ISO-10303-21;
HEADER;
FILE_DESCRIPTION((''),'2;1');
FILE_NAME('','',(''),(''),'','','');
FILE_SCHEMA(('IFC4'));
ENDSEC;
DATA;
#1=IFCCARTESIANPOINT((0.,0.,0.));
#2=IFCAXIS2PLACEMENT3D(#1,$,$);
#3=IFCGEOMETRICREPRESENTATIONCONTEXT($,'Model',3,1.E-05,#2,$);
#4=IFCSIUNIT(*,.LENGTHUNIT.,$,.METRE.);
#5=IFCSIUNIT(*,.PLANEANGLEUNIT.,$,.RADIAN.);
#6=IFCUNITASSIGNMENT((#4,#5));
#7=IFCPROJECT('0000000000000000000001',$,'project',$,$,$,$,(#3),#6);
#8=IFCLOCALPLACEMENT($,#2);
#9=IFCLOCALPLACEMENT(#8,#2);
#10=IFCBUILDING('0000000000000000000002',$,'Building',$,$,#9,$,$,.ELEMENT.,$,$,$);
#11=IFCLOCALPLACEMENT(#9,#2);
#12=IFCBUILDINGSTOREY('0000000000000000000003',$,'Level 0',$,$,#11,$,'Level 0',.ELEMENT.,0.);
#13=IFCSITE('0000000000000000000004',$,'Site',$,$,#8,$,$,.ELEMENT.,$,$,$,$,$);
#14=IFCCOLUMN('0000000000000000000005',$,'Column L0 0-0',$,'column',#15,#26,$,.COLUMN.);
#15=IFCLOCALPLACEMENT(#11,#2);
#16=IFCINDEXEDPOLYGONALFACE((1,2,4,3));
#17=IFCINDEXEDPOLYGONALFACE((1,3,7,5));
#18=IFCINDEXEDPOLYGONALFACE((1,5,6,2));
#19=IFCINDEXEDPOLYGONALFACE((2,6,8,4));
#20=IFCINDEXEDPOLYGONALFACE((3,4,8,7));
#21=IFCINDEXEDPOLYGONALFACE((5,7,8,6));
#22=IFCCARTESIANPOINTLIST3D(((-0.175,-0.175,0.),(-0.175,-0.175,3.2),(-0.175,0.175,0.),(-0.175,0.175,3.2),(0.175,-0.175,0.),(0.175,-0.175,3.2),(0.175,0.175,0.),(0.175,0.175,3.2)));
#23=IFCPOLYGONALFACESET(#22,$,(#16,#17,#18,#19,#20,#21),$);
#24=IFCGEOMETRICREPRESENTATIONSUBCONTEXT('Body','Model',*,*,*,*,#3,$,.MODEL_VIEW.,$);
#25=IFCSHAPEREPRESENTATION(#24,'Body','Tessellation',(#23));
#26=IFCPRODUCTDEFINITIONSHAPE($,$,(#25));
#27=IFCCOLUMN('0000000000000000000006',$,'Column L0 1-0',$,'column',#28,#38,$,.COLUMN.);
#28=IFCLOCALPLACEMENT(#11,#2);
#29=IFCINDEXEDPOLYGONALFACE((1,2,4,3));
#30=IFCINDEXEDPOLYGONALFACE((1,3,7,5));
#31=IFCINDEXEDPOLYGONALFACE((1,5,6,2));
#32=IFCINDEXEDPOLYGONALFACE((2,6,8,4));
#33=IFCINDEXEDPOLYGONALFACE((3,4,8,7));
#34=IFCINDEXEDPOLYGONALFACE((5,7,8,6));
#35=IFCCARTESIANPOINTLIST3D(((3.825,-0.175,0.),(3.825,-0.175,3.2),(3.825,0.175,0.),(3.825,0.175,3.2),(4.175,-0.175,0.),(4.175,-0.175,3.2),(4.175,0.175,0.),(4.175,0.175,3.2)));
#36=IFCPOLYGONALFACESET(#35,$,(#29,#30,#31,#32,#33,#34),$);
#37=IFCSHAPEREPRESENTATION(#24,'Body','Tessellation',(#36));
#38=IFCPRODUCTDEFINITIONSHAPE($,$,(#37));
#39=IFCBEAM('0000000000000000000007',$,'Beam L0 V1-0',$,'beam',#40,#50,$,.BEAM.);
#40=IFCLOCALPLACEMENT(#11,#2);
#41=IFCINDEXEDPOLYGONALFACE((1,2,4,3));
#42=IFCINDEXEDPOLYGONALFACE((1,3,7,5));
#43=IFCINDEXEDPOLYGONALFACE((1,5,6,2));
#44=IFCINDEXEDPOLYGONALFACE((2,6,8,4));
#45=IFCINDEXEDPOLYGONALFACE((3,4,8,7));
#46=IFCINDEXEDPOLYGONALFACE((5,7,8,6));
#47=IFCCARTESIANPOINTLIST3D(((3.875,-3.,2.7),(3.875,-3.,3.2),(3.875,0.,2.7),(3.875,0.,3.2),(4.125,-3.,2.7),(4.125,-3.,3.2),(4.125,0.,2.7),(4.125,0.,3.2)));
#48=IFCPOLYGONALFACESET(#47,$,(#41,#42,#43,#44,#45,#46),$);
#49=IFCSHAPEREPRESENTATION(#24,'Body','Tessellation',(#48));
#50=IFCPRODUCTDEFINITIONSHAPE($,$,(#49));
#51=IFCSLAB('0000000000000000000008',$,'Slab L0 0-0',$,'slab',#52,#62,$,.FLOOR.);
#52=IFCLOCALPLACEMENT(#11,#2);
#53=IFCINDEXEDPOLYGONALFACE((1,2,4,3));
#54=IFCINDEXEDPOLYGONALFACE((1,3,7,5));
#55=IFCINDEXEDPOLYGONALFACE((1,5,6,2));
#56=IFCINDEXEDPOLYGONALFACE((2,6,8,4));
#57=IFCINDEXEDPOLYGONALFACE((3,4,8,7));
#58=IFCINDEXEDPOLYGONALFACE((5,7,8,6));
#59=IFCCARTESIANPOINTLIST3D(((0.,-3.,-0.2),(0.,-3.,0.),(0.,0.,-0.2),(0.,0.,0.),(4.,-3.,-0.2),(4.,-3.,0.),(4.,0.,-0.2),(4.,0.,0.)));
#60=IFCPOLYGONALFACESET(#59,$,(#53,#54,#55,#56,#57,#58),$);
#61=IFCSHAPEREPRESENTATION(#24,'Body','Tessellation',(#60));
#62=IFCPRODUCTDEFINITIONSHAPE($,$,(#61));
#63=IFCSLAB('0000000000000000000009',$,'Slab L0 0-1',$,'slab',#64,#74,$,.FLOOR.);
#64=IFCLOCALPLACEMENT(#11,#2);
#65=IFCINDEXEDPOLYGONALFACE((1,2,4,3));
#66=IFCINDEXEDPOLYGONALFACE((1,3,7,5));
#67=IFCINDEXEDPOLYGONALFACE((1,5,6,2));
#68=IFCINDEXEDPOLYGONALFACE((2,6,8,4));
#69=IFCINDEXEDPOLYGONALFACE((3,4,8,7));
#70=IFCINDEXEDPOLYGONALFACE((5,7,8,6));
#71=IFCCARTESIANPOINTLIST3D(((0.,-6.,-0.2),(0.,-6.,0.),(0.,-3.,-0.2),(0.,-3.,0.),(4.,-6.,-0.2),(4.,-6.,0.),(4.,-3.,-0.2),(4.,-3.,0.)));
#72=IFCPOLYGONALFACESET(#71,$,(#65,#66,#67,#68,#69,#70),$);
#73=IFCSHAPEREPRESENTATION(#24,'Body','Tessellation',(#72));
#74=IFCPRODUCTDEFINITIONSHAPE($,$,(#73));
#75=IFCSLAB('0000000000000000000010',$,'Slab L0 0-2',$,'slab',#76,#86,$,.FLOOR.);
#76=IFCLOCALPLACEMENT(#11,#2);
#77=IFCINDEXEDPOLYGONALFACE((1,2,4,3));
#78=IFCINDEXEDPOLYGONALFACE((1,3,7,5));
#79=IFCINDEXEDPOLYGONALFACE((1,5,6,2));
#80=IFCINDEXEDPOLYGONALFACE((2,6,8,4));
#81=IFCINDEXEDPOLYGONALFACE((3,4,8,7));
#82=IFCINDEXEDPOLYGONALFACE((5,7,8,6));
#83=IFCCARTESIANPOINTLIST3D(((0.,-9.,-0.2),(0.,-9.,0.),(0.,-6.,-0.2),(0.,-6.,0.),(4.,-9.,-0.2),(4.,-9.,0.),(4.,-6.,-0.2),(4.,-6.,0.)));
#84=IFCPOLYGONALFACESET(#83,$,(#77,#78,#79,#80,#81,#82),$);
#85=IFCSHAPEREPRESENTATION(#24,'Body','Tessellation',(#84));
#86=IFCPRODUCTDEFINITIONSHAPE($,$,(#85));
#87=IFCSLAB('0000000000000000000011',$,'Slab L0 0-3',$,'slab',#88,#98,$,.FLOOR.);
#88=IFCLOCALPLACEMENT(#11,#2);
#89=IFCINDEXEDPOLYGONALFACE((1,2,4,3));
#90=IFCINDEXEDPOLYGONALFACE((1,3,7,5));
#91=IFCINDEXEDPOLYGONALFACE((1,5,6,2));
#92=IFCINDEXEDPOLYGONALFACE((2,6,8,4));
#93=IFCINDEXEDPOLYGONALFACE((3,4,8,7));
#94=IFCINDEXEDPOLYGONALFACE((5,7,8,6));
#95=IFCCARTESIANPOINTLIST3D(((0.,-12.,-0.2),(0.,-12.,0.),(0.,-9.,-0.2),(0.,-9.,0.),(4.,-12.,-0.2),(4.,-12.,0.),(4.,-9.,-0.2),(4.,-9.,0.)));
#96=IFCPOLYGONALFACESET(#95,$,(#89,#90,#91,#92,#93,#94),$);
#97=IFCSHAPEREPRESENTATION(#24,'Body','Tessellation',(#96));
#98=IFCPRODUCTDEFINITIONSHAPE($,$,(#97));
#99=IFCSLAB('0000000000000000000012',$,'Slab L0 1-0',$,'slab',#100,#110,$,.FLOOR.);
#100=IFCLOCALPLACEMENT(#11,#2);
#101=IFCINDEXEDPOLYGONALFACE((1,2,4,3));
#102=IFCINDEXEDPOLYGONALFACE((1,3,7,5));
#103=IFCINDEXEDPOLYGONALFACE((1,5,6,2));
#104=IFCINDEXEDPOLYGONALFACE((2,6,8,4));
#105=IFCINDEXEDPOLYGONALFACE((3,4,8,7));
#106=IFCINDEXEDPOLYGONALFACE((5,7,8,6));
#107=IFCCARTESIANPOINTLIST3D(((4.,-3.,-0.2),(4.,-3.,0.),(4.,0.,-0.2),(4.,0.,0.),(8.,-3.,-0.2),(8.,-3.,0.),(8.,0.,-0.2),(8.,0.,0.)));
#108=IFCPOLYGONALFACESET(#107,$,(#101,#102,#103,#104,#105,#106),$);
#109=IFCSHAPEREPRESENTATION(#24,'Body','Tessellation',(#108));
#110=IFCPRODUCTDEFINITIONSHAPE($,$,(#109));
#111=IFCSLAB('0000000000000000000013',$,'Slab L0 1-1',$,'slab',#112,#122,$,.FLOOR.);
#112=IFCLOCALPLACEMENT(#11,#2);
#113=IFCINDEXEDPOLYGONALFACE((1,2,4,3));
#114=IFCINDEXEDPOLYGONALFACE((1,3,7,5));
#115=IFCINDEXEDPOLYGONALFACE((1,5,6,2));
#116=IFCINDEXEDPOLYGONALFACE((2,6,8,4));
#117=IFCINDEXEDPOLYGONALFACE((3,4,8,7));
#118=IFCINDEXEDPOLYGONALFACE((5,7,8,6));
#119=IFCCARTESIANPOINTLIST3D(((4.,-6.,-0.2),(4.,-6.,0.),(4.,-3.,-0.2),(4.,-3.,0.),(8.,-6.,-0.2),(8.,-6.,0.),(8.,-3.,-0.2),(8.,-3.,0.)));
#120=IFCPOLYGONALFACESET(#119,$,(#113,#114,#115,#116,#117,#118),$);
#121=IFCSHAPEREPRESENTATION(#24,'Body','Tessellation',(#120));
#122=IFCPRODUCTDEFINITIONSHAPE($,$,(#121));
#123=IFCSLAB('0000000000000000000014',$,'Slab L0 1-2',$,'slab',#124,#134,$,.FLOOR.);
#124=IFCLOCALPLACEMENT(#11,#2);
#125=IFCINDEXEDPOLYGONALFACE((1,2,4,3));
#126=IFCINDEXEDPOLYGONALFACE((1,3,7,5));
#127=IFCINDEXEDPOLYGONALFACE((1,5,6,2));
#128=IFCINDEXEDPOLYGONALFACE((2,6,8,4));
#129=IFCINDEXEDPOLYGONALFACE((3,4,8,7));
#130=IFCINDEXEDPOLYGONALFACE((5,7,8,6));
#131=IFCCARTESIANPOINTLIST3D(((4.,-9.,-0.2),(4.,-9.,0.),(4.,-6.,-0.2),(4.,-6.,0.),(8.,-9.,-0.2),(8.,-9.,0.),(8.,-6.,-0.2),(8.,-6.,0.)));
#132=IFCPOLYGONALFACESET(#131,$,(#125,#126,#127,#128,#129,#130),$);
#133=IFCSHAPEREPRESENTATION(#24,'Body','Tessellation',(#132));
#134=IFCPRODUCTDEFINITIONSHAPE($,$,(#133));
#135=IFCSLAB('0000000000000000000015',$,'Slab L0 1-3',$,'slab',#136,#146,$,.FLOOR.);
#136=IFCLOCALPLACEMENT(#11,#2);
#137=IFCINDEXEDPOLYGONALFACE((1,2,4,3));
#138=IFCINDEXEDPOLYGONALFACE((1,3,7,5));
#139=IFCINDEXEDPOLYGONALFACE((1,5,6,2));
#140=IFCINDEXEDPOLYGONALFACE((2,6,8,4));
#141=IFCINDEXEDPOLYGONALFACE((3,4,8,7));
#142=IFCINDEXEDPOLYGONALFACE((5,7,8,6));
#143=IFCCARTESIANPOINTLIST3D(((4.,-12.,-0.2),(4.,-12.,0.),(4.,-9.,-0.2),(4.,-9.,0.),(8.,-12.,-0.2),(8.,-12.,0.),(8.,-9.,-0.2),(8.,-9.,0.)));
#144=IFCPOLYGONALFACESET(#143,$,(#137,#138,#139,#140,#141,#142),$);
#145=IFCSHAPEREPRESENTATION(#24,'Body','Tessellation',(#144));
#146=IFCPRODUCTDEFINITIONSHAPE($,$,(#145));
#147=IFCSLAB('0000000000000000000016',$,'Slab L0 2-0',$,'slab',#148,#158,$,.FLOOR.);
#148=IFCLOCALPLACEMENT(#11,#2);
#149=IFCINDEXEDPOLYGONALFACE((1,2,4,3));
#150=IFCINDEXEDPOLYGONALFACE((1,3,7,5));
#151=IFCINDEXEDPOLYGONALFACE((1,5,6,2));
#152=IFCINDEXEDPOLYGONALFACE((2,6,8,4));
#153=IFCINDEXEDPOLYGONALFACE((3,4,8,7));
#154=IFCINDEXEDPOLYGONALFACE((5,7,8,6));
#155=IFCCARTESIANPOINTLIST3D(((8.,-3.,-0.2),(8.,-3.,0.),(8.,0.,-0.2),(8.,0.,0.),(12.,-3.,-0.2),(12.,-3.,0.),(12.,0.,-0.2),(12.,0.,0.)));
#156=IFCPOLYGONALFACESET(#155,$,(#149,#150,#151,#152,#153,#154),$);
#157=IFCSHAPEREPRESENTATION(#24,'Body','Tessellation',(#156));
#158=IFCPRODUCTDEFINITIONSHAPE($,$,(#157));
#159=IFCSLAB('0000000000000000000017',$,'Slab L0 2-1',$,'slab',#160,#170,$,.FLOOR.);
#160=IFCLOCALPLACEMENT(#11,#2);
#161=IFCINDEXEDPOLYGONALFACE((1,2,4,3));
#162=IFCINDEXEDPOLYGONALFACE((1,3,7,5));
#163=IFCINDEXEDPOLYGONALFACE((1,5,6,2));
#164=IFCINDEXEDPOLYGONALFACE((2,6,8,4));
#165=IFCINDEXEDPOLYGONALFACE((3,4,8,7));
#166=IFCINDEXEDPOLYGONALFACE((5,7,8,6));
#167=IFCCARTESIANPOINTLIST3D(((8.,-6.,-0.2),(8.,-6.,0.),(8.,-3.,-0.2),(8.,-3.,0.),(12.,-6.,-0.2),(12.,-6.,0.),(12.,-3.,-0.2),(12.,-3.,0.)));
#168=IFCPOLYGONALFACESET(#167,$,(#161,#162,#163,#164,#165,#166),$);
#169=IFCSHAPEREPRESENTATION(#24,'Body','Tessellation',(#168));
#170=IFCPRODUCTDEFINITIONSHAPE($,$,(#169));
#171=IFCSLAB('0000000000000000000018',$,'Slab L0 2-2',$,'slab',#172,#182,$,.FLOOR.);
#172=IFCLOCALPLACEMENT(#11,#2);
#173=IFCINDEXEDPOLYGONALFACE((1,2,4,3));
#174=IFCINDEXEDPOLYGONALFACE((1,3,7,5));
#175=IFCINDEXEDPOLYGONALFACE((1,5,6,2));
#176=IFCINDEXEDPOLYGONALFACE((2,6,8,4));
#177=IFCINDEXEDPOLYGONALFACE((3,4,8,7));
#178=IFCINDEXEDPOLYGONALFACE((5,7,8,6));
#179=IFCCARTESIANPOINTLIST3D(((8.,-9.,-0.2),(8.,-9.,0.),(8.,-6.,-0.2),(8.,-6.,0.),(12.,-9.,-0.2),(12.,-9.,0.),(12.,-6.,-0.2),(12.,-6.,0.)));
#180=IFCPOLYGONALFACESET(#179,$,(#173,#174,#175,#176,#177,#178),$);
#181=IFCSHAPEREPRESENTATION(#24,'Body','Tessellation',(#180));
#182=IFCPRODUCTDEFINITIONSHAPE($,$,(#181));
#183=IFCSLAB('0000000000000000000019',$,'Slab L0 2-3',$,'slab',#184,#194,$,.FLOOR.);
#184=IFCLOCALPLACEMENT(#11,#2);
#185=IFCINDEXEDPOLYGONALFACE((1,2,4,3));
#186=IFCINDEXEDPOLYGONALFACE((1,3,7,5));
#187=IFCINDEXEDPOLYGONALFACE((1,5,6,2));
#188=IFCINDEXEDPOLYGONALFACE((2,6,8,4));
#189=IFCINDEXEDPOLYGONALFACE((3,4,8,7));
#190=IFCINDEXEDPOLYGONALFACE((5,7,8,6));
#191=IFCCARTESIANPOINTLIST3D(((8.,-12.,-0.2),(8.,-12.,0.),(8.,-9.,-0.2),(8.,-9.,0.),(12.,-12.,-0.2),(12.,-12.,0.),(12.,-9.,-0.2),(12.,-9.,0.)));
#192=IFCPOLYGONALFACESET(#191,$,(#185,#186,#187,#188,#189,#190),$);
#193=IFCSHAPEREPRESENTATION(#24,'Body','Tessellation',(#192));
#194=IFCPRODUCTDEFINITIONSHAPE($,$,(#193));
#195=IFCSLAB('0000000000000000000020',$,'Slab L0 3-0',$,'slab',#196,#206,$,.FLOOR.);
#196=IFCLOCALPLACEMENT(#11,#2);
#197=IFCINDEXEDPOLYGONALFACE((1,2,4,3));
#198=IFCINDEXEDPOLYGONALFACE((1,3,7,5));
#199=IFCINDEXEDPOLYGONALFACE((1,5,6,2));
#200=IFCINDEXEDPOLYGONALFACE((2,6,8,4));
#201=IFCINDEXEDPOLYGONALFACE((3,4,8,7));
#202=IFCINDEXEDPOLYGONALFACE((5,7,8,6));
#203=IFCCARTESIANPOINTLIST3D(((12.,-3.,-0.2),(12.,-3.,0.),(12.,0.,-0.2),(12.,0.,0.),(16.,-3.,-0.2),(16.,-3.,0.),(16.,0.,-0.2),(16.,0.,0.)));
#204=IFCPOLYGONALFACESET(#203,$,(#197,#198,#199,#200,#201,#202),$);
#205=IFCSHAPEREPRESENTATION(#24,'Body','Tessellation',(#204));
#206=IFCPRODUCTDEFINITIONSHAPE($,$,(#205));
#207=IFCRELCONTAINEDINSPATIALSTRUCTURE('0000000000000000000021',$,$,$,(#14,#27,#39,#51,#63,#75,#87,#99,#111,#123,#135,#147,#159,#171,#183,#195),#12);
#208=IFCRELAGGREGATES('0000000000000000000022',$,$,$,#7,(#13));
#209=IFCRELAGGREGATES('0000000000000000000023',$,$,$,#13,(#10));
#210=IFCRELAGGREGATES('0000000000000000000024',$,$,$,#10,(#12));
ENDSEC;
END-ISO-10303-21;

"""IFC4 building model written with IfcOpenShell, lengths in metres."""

from ifc_helpers import new_model, si_unit, frame, origin, origin_2d, place, context, subcontext, project, spatial, polyline, rectangle, outline, extrude, element, save


model = new_model("IFC4")

# Units and contexts
model_context = context("Model", 3, precision=1e-05, world=origin())
body_context = subcontext(model_context, "Body", "Model", "MODEL_VIEW")
ifc_project = project(units=[si_unit("LENGTHUNIT", "METRE"), si_unit("PLANEANGLEUNIT", "RADIAN")], contexts=[model_context])

# Site, building, storey
site_placement = place(None, origin())
site = spatial("IfcSite", under=ifc_project, at=site_placement, Name="Site", CompositionType="ELEMENT")
building_placement = place(site_placement, origin())
building = spatial("IfcBuilding", under=site, at=building_placement, Name="Building", CompositionType="ELEMENT")
storey_placement = place(building_placement, origin())
storey = spatial("IfcBuildingStorey", under=building, at=storey_placement, Name="Level 0", LongName="Level 0", CompositionType="ELEMENT", Elevation=0.0)

# Columns
for number, where, name in (
    (1, (0.0, 0.0, 0.0), "Column L0 0-0"),
    (2, (4.0, 0.0, 0.0), "Column L0 1-0"),
):
    element("IfcColumn", number, at=place(storey_placement, frame(where)), inside=storey, Name=name, ObjectType="column", PredefinedType="COLUMN", context=body_context, shape_type="SweptSolid", body=[
        extrude(rectangle(XDim=0.35, YDim=0.35, at=origin_2d()), origin(), (0.0, 0.0, 1.0), 3.2),
    ])

# Beam
beam_placement = place(storey_placement, frame((4.0, 0.0, 2.95), z_axis=(0.0, -1.0, 0.0), x_axis=(0.0, 0.0, 1.0)))
element("IfcBeam", 3, at=beam_placement, inside=storey, Name="Beam L0 V1-0", ObjectType="beam", PredefinedType="BEAM", context=body_context, shape_type="SweptSolid", body=[
    extrude(rectangle(XDim=0.5, YDim=0.25, at=origin_2d()), origin(), (0.0, 0.0, 1.0), 3.0),
])

# Slabs
slab_1_placement = place(storey_placement, frame((0.0, 0.0, -0.2)))
element("IfcSlab", 4, at=slab_1_placement, inside=storey, Name="Slab L0 0-0", ObjectType="slab", PredefinedType="FLOOR", context=body_context, shape_type="SweptSolid", body=[
    extrude(outline(polyline([(0.0, -3.0), (4.0, -3.0), (4.0, 0.0), (0.0, 0.0), (0.0, -3.0)])), origin(), (0.0, 0.0, 1.0), 0.2),
])
slab_2_placement = place(storey_placement, frame((0.0, 0.0, -0.2)))
element("IfcSlab", 5, at=slab_2_placement, inside=storey, Name="Slab L0 0-1", ObjectType="slab", PredefinedType="FLOOR", context=body_context, shape_type="SweptSolid", body=[
    extrude(outline(polyline([(0.0, -6.0), (4.0, -6.0), (4.0, -3.0), (0.0, -3.0), (0.0, -6.0)])), origin(), (0.0, 0.0, 1.0), 0.2),
])
slab_3_placement = place(storey_placement, frame((0.0, 0.0, -0.2)))
element("IfcSlab", 6, at=slab_3_placement, inside=storey, Name="Slab L0 0-2", ObjectType="slab", PredefinedType="FLOOR", context=body_context, shape_type="SweptSolid", body=[
    extrude(outline(polyline([(0.0, -9.0), (4.0, -9.0), (4.0, -6.0), (0.0, -6.0), (0.0, -9.0)])), origin(), (0.0, 0.0, 1.0), 0.2),
])
slab_4_placement = place(storey_placement, frame((0.0, 0.0, -0.2)))
element("IfcSlab", 7, at=slab_4_placement, inside=storey, Name="Slab L0 0-3", ObjectType="slab", PredefinedType="FLOOR", context=body_context, shape_type="SweptSolid", body=[
    extrude(outline(polyline([(0.0, -12.0), (4.0, -12.0), (4.0, -9.0), (0.0, -9.0), (0.0, -12.0)])), origin(), (0.0, 0.0, 1.0), 0.2),
])
slab_5_placement = place(storey_placement, frame((0.0, 0.0, -0.2)))
element("IfcSlab", 8, at=slab_5_placement, inside=storey, Name="Slab L0 1-0", ObjectType="slab", PredefinedType="FLOOR", context=body_context, shape_type="SweptSolid", body=[
    extrude(outline(polyline([(4.0, -3.0), (8.0, -3.0), (8.0, 0.0), (4.0, 0.0), (4.0, -3.0)])), origin(), (0.0, 0.0, 1.0), 0.2),
])
slab_6_placement = place(storey_placement, frame((0.0, 0.0, -0.2)))
element("IfcSlab", 9, at=slab_6_placement, inside=storey, Name="Slab L0 1-1", ObjectType="slab", PredefinedType="FLOOR", context=body_context, shape_type="SweptSolid", body=[
    extrude(outline(polyline([(4.0, -6.0), (8.0, -6.0), (8.0, -3.0), (4.0, -3.0), (4.0, -6.0)])), origin(), (0.0, 0.0, 1.0), 0.2),
])
slab_7_placement = place(storey_placement, frame((0.0, 0.0, -0.2)))
element("IfcSlab", 10, at=slab_7_placement, inside=storey, Name="Slab L0 1-2", ObjectType="slab", PredefinedType="FLOOR", context=body_context, shape_type="SweptSolid", body=[
    extrude(outline(polyline([(4.0, -9.0), (8.0, -9.0), (8.0, -6.0), (4.0, -6.0), (4.0, -9.0)])), origin(), (0.0, 0.0, 1.0), 0.2),
])
slab_8_placement = place(storey_placement, frame((0.0, 0.0, -0.2)))
element("IfcSlab", 11, at=slab_8_placement, inside=storey, Name="Slab L0 1-3", ObjectType="slab", PredefinedType="FLOOR", context=body_context, shape_type="SweptSolid", body=[
    extrude(outline(polyline([(4.0, -12.0), (8.0, -12.0), (8.0, -9.0), (4.0, -9.0), (4.0, -12.0)])), origin(), (0.0, 0.0, 1.0), 0.2),
])
slab_9_placement = place(storey_placement, frame((0.0, 0.0, -0.2)))
element("IfcSlab", 12, at=slab_9_placement, inside=storey, Name="Slab L0 2-0", ObjectType="slab", PredefinedType="FLOOR", context=body_context, shape_type="SweptSolid", body=[
    extrude(outline(polyline([(8.0, -3.0), (12.0, -3.0), (12.0, 0.0), (8.0, 0.0), (8.0, -3.0)])), origin(), (0.0, 0.0, 1.0), 0.2),
])
slab_10_placement = place(storey_placement, frame((0.0, 0.0, -0.2)))
element("IfcSlab", 13, at=slab_10_placement, inside=storey, Name="Slab L0 2-1", ObjectType="slab", PredefinedType="FLOOR", context=body_context, shape_type="SweptSolid", body=[
    extrude(outline(polyline([(8.0, -6.0), (12.0, -6.0), (12.0, -3.0), (8.0, -3.0), (8.0, -6.0)])), origin(), (0.0, 0.0, 1.0), 0.2),
])
slab_11_placement = place(storey_placement, frame((0.0, 0.0, -0.2)))
element("IfcSlab", 14, at=slab_11_placement, inside=storey, Name="Slab L0 2-2", ObjectType="slab", PredefinedType="FLOOR", context=body_context, shape_type="SweptSolid", body=[
    extrude(outline(polyline([(8.0, -9.0), (12.0, -9.0), (12.0, -6.0), (8.0, -6.0), (8.0, -9.0)])), origin(), (0.0, 0.0, 1.0), 0.2),
])
slab_12_placement = place(storey_placement, frame((0.0, 0.0, -0.2)))
element("IfcSlab", 15, at=slab_12_placement, inside=storey, Name="Slab L0 2-3", ObjectType="slab", PredefinedType="FLOOR", context=body_context, shape_type="SweptSolid", body=[
    extrude(outline(polyline([(8.0, -12.0), (12.0, -12.0), (12.0, -9.0), (8.0, -9.0), (8.0, -12.0)])), origin(), (0.0, 0.0, 1.0), 0.2),
])
slab_13_placement = place(storey_placement, frame((0.0, 0.0, -0.2)))
element("IfcSlab", 16, at=slab_13_placement, inside=storey, Name="Slab L0 3-0", ObjectType="slab", PredefinedType="FLOOR", context=body_context, shape_type="SweptSolid", body=[
    extrude(outline(polyline([(12.0, -3.0), (16.0, -3.0), (16.0, 0.0), (12.0, 0.0), (12.0, -3.0)])), origin(), (0.0, 0.0, 1.0), 0.2),
])

save(model, "model.ifc")
